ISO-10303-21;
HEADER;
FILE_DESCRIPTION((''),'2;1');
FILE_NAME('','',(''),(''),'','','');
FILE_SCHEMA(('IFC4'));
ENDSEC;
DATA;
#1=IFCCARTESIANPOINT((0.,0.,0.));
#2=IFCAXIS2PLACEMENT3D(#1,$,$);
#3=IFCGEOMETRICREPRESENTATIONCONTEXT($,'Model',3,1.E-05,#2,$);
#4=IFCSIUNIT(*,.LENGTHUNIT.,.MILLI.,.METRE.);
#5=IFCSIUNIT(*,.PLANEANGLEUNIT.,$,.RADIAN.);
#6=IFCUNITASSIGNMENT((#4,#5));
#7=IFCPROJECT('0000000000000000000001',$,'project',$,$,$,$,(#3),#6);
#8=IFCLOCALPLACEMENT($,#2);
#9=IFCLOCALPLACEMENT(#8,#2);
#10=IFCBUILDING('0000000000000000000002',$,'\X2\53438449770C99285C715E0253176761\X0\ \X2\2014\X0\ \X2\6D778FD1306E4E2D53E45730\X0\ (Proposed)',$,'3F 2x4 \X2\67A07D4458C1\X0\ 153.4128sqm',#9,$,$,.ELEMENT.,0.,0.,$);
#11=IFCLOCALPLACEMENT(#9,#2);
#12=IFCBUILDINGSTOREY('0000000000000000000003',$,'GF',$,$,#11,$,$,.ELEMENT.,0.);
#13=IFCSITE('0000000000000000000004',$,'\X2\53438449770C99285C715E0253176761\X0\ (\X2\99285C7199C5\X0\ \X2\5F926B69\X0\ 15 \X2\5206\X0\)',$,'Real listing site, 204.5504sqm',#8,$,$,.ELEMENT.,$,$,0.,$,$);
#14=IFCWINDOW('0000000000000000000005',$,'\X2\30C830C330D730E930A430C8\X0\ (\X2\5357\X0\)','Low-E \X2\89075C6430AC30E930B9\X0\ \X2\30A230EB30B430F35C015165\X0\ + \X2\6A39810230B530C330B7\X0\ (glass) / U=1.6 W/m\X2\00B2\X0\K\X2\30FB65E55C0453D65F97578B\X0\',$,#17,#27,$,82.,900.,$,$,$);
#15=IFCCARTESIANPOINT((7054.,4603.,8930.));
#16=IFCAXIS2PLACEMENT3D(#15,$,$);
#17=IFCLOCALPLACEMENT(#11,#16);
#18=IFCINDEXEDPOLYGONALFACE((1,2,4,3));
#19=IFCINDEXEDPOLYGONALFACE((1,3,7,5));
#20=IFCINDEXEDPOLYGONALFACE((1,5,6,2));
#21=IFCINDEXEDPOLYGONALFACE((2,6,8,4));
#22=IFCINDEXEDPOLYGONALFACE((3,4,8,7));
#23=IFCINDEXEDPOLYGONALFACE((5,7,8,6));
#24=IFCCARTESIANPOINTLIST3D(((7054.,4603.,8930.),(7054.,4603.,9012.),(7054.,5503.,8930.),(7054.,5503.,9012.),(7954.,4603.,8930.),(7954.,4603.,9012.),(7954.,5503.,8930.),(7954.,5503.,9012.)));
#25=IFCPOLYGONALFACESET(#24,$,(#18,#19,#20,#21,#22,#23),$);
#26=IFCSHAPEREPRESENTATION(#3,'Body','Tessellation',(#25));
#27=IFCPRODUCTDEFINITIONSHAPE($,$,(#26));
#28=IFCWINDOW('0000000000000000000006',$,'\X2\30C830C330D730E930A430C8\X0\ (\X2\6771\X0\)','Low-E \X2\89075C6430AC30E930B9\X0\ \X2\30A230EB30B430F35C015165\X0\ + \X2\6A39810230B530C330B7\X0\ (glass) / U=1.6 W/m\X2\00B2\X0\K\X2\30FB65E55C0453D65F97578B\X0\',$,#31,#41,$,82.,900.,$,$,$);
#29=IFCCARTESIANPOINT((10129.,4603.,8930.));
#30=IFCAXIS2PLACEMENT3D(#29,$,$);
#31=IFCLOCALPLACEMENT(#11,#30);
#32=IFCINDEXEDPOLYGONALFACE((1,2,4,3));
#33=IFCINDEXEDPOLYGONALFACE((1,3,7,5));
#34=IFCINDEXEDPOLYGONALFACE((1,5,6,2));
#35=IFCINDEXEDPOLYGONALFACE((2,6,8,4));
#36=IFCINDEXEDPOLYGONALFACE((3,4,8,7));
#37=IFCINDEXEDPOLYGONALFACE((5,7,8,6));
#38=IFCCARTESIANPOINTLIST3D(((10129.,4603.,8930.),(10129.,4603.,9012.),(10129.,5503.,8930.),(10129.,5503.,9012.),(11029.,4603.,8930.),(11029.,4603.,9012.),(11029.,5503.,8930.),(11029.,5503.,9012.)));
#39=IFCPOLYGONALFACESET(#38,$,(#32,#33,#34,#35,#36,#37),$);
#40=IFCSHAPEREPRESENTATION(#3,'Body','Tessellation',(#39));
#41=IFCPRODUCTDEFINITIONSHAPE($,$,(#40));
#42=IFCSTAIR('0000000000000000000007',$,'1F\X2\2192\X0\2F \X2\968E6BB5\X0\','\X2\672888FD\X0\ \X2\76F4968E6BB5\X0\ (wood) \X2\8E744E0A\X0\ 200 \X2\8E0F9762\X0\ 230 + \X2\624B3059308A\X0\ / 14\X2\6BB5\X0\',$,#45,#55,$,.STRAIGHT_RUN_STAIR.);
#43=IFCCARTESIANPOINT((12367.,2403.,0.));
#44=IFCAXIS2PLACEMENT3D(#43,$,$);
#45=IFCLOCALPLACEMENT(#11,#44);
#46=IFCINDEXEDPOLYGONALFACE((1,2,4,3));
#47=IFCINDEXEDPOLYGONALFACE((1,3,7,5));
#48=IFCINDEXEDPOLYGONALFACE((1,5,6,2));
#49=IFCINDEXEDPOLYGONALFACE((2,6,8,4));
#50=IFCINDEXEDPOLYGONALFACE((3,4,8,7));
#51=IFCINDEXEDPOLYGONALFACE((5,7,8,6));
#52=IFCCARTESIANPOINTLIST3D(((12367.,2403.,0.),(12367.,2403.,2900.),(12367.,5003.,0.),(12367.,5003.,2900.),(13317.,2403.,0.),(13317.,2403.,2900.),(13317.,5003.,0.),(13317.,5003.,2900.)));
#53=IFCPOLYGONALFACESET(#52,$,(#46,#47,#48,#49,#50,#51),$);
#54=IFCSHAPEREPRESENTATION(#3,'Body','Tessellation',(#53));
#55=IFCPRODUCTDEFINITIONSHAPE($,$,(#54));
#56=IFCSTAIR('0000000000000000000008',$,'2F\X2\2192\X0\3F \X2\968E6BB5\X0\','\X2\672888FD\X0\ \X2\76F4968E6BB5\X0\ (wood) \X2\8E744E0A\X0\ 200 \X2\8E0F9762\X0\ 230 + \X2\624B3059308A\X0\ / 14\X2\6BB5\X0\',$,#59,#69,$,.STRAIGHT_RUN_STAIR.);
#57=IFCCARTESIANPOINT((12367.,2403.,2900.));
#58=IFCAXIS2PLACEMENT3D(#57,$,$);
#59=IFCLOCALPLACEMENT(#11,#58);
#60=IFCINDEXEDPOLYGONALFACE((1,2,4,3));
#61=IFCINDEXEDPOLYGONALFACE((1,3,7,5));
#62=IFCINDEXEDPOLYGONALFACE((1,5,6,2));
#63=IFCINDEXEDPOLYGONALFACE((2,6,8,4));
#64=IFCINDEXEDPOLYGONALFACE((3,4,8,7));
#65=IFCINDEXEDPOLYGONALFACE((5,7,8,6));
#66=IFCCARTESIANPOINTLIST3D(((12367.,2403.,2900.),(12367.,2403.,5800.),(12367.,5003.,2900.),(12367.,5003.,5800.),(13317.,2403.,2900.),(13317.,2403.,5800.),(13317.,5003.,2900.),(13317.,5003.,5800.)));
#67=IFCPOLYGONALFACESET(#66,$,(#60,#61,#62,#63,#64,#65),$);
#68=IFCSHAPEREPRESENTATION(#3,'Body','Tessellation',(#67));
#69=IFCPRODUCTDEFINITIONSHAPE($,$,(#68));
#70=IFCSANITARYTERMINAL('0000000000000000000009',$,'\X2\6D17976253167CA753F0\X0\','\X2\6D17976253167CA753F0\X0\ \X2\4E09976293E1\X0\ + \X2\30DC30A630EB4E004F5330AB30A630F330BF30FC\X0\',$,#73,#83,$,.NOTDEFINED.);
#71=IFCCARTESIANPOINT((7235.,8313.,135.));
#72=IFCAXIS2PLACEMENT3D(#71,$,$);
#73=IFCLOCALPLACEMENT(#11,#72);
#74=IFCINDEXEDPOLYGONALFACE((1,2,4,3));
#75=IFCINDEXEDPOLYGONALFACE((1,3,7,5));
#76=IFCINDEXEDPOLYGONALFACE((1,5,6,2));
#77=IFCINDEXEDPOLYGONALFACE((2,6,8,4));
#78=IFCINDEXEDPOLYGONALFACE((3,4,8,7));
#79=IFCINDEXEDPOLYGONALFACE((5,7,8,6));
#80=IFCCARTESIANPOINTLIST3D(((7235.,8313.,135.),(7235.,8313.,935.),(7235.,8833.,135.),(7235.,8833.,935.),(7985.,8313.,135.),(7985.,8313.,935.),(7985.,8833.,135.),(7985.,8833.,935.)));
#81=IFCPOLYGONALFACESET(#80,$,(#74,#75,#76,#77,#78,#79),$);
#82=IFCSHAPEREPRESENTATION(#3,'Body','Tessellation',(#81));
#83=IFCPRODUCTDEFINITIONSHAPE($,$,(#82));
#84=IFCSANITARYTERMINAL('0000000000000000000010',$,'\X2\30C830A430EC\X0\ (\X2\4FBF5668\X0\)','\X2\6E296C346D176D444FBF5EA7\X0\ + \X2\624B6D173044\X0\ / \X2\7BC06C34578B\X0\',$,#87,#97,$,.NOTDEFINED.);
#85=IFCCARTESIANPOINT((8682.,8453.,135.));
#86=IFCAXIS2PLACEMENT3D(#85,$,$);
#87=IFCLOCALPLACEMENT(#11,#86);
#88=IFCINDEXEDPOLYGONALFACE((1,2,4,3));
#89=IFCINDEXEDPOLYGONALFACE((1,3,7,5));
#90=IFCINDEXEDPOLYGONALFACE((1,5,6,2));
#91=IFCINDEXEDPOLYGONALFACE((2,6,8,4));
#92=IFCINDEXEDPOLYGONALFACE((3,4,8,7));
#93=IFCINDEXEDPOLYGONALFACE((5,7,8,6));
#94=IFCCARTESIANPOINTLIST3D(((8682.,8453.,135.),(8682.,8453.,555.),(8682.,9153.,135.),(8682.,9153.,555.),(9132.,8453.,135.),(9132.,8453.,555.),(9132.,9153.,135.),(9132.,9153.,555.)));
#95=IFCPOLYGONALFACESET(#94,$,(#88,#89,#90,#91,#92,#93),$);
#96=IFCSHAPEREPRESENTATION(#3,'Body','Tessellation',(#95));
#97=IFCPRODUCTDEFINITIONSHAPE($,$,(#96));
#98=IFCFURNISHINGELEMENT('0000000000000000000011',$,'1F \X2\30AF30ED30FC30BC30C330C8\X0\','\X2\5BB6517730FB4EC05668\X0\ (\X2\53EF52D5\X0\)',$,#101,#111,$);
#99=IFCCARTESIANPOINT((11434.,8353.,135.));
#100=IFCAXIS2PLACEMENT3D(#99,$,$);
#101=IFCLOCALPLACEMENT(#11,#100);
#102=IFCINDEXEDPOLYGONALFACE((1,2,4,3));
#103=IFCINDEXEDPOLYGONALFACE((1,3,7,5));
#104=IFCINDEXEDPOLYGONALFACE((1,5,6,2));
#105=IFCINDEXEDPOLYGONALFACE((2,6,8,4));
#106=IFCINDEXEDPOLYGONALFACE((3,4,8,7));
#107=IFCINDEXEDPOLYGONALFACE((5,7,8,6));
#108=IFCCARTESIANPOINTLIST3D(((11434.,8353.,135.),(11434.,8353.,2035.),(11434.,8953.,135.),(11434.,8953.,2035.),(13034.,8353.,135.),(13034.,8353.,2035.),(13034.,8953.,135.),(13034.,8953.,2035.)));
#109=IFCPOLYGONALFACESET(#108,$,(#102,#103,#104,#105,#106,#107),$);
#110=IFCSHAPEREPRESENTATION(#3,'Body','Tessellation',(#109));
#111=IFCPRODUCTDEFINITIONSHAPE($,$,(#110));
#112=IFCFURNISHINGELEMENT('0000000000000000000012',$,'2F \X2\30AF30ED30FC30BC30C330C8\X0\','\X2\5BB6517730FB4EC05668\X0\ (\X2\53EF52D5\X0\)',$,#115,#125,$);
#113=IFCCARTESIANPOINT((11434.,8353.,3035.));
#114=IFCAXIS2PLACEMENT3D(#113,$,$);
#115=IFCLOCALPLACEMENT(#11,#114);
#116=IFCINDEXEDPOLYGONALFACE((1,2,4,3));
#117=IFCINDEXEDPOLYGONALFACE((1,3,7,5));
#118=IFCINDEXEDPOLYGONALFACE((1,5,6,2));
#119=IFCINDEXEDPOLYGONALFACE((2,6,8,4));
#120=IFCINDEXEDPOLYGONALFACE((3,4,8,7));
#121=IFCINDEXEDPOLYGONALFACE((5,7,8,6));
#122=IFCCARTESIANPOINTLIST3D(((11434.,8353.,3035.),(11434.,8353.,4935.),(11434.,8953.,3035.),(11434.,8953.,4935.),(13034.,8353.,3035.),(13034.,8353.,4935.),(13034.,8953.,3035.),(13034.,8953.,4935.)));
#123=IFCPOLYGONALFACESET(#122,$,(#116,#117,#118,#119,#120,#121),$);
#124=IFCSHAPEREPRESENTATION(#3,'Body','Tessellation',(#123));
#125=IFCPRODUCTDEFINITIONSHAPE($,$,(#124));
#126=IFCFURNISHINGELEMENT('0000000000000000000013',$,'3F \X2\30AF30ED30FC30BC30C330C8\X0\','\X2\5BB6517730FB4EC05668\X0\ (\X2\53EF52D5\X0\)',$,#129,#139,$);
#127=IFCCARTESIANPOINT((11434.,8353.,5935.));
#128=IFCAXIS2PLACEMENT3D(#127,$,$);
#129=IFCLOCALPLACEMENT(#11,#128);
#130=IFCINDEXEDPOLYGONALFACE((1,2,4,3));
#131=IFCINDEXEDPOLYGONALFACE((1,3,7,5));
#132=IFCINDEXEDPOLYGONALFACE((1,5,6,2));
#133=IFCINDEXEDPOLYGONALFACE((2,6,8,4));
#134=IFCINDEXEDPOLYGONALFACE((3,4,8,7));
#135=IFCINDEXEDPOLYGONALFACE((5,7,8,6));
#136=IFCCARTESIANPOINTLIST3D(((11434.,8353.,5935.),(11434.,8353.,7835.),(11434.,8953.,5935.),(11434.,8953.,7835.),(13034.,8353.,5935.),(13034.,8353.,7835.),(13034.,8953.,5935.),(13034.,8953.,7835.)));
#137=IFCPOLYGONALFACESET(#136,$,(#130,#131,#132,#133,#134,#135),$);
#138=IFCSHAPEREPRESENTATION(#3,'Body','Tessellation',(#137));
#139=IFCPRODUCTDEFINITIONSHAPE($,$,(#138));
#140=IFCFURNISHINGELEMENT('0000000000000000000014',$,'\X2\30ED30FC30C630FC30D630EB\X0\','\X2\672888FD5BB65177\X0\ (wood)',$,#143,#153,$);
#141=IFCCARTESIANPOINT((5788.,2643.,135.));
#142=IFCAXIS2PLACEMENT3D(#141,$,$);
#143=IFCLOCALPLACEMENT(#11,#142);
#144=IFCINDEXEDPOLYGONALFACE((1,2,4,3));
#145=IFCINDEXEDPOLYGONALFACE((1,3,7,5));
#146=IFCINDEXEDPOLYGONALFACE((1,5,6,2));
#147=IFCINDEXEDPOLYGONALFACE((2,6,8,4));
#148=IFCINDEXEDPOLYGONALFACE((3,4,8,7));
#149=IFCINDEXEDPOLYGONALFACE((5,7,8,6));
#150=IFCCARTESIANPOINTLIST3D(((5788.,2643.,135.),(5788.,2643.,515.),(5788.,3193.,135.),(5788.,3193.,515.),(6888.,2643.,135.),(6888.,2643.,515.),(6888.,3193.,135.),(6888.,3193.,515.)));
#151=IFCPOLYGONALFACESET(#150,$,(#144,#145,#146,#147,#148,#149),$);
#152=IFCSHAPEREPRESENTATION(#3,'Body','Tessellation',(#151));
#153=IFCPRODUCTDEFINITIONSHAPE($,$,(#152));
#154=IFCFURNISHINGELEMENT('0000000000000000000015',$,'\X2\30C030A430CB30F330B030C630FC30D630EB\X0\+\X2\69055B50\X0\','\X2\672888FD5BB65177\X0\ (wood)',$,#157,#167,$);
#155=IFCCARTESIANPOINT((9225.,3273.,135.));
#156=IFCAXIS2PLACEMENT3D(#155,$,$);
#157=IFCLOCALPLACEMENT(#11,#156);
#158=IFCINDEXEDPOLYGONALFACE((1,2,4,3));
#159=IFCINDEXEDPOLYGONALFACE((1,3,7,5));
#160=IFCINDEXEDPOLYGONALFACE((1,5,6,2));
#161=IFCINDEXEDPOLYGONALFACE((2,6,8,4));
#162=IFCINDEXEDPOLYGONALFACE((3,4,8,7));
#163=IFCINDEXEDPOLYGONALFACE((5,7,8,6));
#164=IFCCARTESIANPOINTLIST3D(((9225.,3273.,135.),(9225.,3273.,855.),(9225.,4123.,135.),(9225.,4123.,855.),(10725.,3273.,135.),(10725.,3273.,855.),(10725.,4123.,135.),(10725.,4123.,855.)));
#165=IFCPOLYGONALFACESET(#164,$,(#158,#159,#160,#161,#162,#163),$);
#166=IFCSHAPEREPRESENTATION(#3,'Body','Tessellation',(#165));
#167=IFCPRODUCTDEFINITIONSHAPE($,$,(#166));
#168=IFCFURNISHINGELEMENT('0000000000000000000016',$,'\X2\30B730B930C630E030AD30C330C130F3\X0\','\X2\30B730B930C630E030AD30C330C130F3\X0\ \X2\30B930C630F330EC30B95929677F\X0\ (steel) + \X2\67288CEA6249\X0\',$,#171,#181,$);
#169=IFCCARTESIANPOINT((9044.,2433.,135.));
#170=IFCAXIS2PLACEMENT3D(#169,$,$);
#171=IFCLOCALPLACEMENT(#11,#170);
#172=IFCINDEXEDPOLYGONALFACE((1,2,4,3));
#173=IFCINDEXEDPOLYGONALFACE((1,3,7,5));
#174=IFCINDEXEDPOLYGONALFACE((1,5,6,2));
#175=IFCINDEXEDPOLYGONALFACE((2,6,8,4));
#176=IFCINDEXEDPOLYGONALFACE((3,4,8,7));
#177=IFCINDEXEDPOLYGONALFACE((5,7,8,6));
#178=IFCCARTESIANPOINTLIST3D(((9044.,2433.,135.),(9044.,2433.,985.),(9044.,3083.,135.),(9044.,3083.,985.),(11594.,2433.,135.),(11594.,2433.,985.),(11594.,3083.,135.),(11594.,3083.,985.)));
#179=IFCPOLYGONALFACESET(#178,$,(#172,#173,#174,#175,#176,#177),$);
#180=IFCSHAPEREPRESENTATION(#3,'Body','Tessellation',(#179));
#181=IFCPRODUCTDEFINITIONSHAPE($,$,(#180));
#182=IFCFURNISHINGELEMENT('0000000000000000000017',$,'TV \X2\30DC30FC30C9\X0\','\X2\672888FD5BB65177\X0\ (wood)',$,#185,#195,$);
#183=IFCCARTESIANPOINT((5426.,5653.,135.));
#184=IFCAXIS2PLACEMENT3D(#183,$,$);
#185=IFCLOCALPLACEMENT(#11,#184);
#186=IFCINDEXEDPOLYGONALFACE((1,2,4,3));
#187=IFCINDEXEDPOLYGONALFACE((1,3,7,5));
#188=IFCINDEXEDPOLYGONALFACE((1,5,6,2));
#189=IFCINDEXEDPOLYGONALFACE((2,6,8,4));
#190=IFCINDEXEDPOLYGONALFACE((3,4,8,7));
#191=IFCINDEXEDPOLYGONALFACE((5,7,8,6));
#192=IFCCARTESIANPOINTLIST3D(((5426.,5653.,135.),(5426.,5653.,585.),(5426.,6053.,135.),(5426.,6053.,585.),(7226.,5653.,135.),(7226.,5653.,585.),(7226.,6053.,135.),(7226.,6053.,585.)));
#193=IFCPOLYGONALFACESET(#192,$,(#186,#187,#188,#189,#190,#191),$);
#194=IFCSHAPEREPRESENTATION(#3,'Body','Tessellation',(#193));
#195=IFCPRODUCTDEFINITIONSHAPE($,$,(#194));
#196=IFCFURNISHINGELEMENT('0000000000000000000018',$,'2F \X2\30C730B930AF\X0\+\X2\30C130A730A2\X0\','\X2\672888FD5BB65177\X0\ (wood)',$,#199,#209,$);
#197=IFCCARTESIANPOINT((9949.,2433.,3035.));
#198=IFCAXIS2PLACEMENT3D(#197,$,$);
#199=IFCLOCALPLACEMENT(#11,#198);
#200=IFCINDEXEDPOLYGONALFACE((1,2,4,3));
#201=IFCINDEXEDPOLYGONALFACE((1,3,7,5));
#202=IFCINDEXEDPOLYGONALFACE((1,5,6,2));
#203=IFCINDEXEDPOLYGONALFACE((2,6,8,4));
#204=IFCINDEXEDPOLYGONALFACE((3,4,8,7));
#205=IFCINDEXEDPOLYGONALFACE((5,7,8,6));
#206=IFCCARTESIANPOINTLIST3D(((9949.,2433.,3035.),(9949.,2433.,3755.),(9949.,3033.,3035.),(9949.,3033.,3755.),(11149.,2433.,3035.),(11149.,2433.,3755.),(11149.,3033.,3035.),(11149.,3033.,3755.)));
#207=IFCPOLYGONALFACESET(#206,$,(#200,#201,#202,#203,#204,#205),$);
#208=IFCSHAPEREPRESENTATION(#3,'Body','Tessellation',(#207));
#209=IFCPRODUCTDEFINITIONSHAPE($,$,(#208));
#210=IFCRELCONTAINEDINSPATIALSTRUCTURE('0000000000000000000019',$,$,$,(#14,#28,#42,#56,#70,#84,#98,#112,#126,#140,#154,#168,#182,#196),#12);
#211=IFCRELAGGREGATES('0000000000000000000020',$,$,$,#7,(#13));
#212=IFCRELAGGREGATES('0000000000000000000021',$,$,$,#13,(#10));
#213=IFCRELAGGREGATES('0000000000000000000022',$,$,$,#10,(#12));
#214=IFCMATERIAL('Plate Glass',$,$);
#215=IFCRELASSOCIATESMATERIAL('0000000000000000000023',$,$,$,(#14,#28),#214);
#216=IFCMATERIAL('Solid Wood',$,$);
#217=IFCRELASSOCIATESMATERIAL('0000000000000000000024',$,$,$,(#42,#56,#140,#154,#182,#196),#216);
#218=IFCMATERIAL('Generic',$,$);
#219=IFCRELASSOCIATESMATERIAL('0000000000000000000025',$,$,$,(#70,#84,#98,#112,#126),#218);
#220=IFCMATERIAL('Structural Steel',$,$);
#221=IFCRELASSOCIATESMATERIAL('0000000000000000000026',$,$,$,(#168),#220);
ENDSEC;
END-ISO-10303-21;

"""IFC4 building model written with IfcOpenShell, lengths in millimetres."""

from ifc_helpers import new_model, si_unit, frame, frame_2d, origin, place, context, project, spatial, rectangle, extrude, material, element, save


model = new_model("IFC4")

# Units and contexts
model_context = context("Model", 3, precision=1e-05, world=origin())
ifc_project = project(units=[si_unit("LENGTHUNIT", "METRE", prefix="MILLI"), si_unit("PLANEANGLEUNIT", "RADIAN")], contexts=[model_context])

# Site, building, storey
site_placement = place(None, origin())
site = spatial("IfcSite", under=ifc_project, at=site_placement, Name="千葉県館山市北条 (館山駅 徒歩 15 分)", ObjectType="Real listing site, 204.5504sqm", CompositionType="ELEMENT", RefElevation=0.0)
building_placement = place(site_placement, origin())
building = spatial("IfcBuilding", under=site, at=building_placement, Name="千葉県館山市北条 — 海近の中古地 (Proposed)", ObjectType="3F 2x4 枠組壁 153.4128sqm", CompositionType="ELEMENT", ElevationOfRefHeight=0.0, ElevationOfTerrain=0.0)
storey_placement = place(building_placement, origin())
storey = spatial("IfcBuildingStorey", under=building, at=storey_placement, Name="GF", CompositionType="ELEMENT", Elevation=0.0)

# Shared definitions
ifc_material_1 = material(Name="Solid Wood")
ifc_material_2 = material(Name="Plate Glass")

# Windows
window_1_placement = place(storey_placement, frame((7054.0, 4603.0, 8930.0)))
element("IfcWindow", 1, at=window_1_placement, inside=storey, material=ifc_material_2, Name="トップライト (南)", Description="Low-E 複層ガラス アルゴン封入 + 樹脂サッシ (glass) / U=1.6 W/m²K・日射取得型", OverallHeight=82.0, OverallWidth=900.0, context=model_context, shape_type="SweptSolid", body=[
    extrude(rectangle(XDim=900.0, YDim=900.0, at=frame_2d((450.0, 450.0))), frame((7054.0, 4603.0, 8930.0)), (0.0, 0.0, 1.0), 82.0),
])
window_2_placement = place(storey_placement, frame((10129.0, 4603.0, 8930.0)))
element("IfcWindow", 2, at=window_2_placement, inside=storey, material=ifc_material_2, Name="トップライト (東)", Description="Low-E 複層ガラス アルゴン封入 + 樹脂サッシ (glass) / U=1.6 W/m²K・日射取得型", OverallHeight=82.0, OverallWidth=900.0, context=model_context, shape_type="SweptSolid", body=[
    extrude(rectangle(XDim=900.0, YDim=900.0, at=frame_2d((450.0, 450.0))), frame((10129.0, 4603.0, 8930.0)), (0.0, 0.0, 1.0), 82.0),
])

# Stairs
stair_1_placement = place(storey_placement, frame((12367.0, 2403.0, 0.0)))
element("IfcStair", 3, at=stair_1_placement, inside=storey, material=ifc_material_1, Name="1F→2F 階段", Description="木製 直階段 (wood) 蹴上 200 踏面 230 + 手すり / 14段", PredefinedType="STRAIGHT_RUN_STAIR", context=model_context, shape_type="SweptSolid", body=[
    extrude(rectangle(XDim=950.0, YDim=2600.0, at=frame_2d((475.0, 1300.0))), frame((12367.0, 2403.0, 0.0)), (0.0, 0.0, 1.0), 2900.0),
])
stair_2_placement = place(storey_placement, frame((12367.0, 2403.0, 2900.0)))
element("IfcStair", 4, at=stair_2_placement, inside=storey, material=ifc_material_1, Name="2F→3F 階段", Description="木製 直階段 (wood) 蹴上 200 踏面 230 + 手すり / 14段", PredefinedType="STRAIGHT_RUN_STAIR", context=model_context, shape_type="SweptSolid", body=[
    extrude(rectangle(XDim=950.0, YDim=2600.0, at=frame_2d((475.0, 1300.0))), frame((12367.0, 2403.0, 2900.0)), (0.0, 0.0, 1.0), 2900.0),
])

# Sanitary terminals
ifc_material_3 = material(Name="Generic")
sanitary_terminal_1_placement = place(storey_placement, frame((7235.0, 8313.0, 135.0)))
element("IfcSanitaryTerminal", 5, at=sanitary_terminal_1_placement, inside=storey, material=ifc_material_3, Name="洗面化粧台", Description="洗面化粧台 三面鏡 + ボウル一体カウンター", PredefinedType="NOTDEFINED", context=model_context, shape_type="SweptSolid", body=[
    extrude(rectangle(XDim=750.0, YDim=520.0, at=frame_2d((375.0, 260.0))), frame((7235.0, 8313.0, 135.0)), (0.0, 0.0, 1.0), 800.0),
])
sanitary_terminal_2_placement = place(storey_placement, frame((8682.0, 8453.0, 135.0)))
element("IfcSanitaryTerminal", 6, at=sanitary_terminal_2_placement, inside=storey, material=ifc_material_3, Name="トイレ (便器)", Description="温水洗浄便座 + 手洗い / 節水型", PredefinedType="NOTDEFINED", context=model_context, shape_type="SweptSolid", body=[
    extrude(rectangle(XDim=450.0, YDim=700.0, at=frame_2d((225.0, 350.0))), frame((8682.0, 8453.0, 135.0)), (0.0, 0.0, 1.0), 420.0),
])

# Furnishing elements
furnishing_1_placement = place(storey_placement, frame((11434.0, 8353.0, 135.0)))
element("IfcFurnishingElement", 7, at=furnishing_1_placement, inside=storey, material=ifc_material_3, Name="1F クローゼット", Description="家具・什器 (可動)", context=model_context, shape_type="SweptSolid", body=[
    extrude(rectangle(XDim=1600.0, YDim=600.0, at=frame_2d((800.0, 300.0))), frame((11434.0, 8353.0, 135.0)), (0.0, 0.0, 1.0), 1900.0),
])
furnishing_2_placement = place(storey_placement, frame((11434.0, 8353.0, 3035.0)))
element("IfcFurnishingElement", 8, at=furnishing_2_placement, inside=storey, material=ifc_material_3, Name="2F クローゼット", Description="家具・什器 (可動)", context=model_context, shape_type="SweptSolid", body=[
    extrude(rectangle(XDim=1600.0, YDim=600.0, at=frame_2d((800.0, 300.0))), frame((11434.0, 8353.0, 3035.0)), (0.0, 0.0, 1.0), 1900.0),
])
furnishing_3_placement = place(storey_placement, frame((11434.0, 8353.0, 5935.0)))
element("IfcFurnishingElement", 9, at=furnishing_3_placement, inside=storey, material=ifc_material_3, Name="3F クローゼット", Description="家具・什器 (可動)", context=model_context, shape_type="SweptSolid", body=[
    extrude(rectangle(XDim=1600.0, YDim=600.0, at=frame_2d((800.0, 300.0))), frame((11434.0, 8353.0, 5935.0)), (0.0, 0.0, 1.0), 1900.0),
])
furnishing_4_placement = place(storey_placement, frame((5788.0, 2643.0, 135.0)))
element("IfcFurnishingElement", 10, at=furnishing_4_placement, inside=storey, material=ifc_material_1, Name="ローテーブル", Description="木製家具 (wood)", context=model_context, shape_type="SweptSolid", body=[
    extrude(rectangle(XDim=1100.0, YDim=550.0, at=frame_2d((550.0, 275.0))), frame((5788.0, 2643.0, 135.0)), (0.0, 0.0, 1.0), 380.0),
])
furnishing_5_placement = place(storey_placement, frame((9225.0, 3273.0, 135.0)))
element("IfcFurnishingElement", 11, at=furnishing_5_placement, inside=storey, material=ifc_material_1, Name="ダイニングテーブル+椅子", Description="木製家具 (wood)", context=model_context, shape_type="SweptSolid", body=[
    extrude(rectangle(XDim=1500.0, YDim=850.0, at=frame_2d((750.0, 425.0))), frame((9225.0, 3273.0, 135.0)), (0.0, 0.0, 1.0), 720.0),
])
ifc_material_4 = material(Name="Structural Steel")
furnishing_6_placement = place(storey_placement, frame((9044.0, 2433.0, 135.0)))
element("IfcFurnishingElement", 12, at=furnishing_6_placement, inside=storey, material=ifc_material_4, Name="システムキッチン", Description="システムキッチン ステンレス天板 (steel) + 木質扉", context=model_context, shape_type="SweptSolid", body=[
    extrude(rectangle(XDim=2550.0, YDim=650.0, at=frame_2d((1275.0, 325.0))), frame((9044.0, 2433.0, 135.0)), (0.0, 0.0, 1.0), 850.0),
])
furnishing_7_placement = place(storey_placement, frame((5426.0, 5653.0, 135.0)))
element("IfcFurnishingElement", 13, at=furnishing_7_placement, inside=storey, material=ifc_material_1, Name="TV ボード", Description="木製家具 (wood)", context=model_context, shape_type="SweptSolid", body=[
    extrude(rectangle(XDim=1800.0, YDim=400.0, at=frame_2d((900.0, 200.0))), frame((5426.0, 5653.0, 135.0)), (0.0, 0.0, 1.0), 450.0),
])
furnishing_8_placement = place(storey_placement, frame((9949.0, 2433.0, 3035.0)))
element("IfcFurnishingElement", 14, at=furnishing_8_placement, inside=storey, material=ifc_material_1, Name="2F デスク+チェア", Description="木製家具 (wood)", context=model_context, shape_type="SweptSolid", body=[
    extrude(rectangle(XDim=1200.0, YDim=600.0, at=frame_2d((600.0, 300.0))), frame((9949.0, 2433.0, 3035.0)), (0.0, 0.0, 1.0), 720.0),
])

save(model, "model.ifc")
